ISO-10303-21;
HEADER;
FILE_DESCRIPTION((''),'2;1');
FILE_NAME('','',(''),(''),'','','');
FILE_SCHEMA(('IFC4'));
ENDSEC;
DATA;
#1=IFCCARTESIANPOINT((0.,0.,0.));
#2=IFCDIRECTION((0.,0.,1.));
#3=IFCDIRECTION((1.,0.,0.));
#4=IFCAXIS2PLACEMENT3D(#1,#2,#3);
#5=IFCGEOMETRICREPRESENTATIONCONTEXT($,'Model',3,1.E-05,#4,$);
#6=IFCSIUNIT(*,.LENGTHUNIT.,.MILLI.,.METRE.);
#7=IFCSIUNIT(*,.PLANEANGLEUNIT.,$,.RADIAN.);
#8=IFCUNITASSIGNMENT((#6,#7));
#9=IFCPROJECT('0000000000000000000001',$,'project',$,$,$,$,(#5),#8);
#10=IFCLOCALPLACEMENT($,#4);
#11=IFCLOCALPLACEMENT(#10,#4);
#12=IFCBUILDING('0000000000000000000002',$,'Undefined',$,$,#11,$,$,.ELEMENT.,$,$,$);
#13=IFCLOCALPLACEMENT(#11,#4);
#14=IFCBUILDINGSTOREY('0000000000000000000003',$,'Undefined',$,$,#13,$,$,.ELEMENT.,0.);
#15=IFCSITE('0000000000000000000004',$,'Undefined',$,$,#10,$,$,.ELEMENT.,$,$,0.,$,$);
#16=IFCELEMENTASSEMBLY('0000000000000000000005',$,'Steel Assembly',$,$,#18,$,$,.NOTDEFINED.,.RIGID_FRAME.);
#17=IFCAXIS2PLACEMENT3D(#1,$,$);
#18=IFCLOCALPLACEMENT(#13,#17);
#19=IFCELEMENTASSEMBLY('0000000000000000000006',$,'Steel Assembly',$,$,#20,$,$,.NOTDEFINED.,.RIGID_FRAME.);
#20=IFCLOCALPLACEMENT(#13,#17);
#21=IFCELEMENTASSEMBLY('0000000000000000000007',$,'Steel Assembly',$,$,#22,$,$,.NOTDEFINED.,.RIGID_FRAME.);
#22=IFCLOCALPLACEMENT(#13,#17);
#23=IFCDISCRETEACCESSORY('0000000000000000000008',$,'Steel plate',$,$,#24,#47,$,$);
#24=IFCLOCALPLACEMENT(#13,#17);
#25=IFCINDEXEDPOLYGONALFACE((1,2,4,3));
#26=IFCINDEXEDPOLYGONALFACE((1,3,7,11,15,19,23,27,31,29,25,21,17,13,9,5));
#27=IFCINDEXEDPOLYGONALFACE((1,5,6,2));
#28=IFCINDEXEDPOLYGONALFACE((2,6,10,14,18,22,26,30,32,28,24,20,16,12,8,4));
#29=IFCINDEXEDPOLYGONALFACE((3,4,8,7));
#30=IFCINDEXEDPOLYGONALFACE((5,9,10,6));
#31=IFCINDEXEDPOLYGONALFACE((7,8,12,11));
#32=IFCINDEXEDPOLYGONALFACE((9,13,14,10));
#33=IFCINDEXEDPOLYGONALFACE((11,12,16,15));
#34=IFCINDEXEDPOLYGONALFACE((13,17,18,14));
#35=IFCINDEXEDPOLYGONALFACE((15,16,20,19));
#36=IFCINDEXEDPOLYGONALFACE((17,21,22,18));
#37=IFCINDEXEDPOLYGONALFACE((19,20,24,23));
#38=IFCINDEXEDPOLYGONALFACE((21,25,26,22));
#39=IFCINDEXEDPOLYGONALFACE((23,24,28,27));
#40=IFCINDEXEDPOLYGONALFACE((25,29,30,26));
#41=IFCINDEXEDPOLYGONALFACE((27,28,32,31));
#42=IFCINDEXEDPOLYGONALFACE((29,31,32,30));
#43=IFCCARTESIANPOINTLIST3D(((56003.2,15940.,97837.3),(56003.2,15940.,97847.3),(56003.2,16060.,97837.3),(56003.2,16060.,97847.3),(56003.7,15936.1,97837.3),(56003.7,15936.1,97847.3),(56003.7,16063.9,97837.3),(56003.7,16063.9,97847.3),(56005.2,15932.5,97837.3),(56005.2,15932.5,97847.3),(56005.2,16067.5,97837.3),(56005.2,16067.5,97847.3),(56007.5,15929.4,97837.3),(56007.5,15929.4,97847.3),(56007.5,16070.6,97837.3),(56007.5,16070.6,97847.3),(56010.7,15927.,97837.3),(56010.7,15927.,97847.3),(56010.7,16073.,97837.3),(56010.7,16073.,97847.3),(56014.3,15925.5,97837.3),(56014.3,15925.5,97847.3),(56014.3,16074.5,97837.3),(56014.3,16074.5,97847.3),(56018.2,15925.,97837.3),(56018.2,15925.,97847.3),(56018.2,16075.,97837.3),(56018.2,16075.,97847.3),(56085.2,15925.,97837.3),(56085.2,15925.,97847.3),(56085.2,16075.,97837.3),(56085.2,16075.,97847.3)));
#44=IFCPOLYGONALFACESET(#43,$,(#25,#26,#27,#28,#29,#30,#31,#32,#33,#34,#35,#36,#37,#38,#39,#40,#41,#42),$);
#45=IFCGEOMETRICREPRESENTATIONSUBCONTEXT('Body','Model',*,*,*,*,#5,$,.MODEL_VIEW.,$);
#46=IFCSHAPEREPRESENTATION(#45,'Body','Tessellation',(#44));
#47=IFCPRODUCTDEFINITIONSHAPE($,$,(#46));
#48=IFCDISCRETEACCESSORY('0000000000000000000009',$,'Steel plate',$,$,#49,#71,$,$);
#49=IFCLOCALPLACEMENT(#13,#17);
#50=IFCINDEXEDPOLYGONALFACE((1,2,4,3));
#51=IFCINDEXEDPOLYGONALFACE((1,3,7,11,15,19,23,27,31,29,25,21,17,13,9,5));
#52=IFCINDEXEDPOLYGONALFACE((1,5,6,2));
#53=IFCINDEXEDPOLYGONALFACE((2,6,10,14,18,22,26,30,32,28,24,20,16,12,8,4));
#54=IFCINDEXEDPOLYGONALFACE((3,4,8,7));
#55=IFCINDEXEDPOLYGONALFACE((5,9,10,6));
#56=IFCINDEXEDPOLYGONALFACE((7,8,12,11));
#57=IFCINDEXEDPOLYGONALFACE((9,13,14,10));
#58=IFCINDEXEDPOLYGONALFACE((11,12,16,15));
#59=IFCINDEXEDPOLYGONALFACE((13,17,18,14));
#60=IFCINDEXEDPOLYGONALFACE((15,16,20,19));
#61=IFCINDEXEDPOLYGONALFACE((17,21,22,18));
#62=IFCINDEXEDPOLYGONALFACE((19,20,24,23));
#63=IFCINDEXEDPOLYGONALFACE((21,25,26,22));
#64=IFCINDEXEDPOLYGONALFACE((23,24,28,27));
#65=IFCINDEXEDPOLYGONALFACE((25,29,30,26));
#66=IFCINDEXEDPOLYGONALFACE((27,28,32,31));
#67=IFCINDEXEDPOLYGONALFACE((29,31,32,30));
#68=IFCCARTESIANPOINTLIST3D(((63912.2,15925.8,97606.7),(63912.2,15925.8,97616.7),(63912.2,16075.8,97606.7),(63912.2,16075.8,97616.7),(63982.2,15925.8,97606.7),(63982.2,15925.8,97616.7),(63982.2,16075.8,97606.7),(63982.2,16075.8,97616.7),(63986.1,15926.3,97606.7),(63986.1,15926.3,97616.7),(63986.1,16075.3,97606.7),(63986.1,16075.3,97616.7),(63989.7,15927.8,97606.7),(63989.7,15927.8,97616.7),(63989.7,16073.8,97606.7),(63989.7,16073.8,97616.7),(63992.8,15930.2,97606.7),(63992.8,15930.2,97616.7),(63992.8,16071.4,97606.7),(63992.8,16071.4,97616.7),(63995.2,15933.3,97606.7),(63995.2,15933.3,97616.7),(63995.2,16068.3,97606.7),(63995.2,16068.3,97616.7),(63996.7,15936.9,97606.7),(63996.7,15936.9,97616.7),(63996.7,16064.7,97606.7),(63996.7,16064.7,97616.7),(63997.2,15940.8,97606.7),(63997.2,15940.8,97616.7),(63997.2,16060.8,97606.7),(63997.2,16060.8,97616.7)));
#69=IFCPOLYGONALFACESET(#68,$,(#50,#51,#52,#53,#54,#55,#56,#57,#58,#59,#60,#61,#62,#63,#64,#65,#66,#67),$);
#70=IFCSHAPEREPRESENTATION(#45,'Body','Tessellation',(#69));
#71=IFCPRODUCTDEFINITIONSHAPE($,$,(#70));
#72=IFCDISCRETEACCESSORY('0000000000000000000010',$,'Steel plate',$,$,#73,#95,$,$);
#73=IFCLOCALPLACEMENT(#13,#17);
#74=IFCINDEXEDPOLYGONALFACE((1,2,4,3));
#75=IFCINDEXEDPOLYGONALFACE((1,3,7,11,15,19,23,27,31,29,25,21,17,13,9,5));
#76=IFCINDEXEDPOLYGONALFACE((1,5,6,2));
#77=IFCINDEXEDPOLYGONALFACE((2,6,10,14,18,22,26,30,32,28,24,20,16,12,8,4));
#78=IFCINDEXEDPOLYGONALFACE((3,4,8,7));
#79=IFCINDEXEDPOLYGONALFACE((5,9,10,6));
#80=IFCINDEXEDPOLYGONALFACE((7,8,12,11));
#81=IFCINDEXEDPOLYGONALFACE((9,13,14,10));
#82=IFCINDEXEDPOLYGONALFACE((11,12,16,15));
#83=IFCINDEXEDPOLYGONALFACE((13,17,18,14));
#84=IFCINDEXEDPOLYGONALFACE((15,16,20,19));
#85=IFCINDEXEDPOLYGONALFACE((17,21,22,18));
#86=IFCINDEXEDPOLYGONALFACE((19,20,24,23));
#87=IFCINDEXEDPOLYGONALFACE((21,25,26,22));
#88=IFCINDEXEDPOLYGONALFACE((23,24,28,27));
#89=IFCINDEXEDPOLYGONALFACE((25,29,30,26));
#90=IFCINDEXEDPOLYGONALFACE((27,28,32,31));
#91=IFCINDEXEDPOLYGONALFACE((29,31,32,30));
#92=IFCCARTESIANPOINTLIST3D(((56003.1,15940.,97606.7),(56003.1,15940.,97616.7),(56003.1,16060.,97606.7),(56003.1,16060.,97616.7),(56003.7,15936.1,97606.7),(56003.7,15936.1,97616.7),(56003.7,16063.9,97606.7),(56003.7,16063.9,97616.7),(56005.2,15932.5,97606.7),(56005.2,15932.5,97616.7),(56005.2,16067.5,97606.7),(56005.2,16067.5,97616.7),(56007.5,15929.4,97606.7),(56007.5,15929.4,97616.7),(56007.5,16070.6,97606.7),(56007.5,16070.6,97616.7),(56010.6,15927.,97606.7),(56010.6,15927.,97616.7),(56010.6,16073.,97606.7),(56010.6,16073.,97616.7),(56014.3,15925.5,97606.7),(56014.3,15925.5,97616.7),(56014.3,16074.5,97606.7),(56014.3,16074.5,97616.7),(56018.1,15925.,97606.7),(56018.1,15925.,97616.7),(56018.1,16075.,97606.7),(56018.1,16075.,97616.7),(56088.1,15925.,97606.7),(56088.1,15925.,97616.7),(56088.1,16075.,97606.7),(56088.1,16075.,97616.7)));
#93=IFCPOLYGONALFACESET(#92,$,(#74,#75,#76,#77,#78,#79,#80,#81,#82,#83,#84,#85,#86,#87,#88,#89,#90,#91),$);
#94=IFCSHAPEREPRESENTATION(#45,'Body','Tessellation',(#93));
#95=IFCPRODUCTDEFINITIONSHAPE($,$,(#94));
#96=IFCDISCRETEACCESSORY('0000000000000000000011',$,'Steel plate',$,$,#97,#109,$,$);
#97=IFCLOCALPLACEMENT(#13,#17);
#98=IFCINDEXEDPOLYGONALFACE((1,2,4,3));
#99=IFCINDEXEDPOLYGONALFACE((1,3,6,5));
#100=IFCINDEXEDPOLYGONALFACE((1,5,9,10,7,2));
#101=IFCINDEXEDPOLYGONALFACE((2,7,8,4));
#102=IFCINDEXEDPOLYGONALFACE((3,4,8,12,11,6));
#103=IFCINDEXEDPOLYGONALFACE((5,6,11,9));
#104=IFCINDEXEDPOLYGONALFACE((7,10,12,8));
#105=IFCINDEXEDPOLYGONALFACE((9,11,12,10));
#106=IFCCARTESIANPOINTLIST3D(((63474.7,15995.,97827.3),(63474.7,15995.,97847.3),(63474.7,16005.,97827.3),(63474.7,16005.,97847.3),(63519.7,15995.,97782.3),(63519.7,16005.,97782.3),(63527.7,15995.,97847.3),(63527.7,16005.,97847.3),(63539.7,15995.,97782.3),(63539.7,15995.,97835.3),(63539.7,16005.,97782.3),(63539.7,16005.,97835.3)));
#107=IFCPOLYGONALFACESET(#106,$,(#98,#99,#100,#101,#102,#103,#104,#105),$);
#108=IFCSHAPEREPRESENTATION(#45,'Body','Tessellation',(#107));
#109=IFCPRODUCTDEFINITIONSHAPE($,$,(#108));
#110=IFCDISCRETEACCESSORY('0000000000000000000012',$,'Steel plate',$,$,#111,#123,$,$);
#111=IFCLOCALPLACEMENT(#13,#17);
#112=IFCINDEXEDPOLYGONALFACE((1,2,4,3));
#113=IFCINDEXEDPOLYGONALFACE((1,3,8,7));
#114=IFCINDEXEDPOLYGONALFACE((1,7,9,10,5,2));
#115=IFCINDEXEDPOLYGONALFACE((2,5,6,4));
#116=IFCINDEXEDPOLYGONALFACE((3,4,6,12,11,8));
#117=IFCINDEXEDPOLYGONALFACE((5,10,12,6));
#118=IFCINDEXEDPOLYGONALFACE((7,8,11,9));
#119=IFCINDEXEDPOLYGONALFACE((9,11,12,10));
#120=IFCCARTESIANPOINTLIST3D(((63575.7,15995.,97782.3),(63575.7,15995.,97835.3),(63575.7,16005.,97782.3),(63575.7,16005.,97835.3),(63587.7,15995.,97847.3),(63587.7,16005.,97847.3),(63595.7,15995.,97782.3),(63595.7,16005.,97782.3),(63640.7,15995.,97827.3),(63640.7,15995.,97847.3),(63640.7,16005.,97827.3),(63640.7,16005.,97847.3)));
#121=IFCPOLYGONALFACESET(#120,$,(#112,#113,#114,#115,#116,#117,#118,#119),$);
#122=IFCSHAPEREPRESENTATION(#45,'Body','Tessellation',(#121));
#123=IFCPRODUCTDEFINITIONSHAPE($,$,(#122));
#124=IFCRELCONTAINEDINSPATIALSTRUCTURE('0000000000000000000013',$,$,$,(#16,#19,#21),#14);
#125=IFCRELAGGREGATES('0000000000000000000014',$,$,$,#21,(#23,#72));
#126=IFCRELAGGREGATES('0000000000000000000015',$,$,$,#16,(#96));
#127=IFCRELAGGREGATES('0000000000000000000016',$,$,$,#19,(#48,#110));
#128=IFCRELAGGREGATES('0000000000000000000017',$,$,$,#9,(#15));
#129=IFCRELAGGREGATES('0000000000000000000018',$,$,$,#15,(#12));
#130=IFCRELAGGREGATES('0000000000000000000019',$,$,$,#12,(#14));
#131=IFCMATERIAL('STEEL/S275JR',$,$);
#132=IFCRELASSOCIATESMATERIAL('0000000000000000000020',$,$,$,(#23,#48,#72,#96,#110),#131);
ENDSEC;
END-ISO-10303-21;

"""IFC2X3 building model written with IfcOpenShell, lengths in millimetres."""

from ifc_helpers import new_model, si_unit, frame, frame_2d, origin_with_axes, place, context, subcontext, project, spatial, polyline, circle_curve, parameter, trimmed, segment, composite_curve, outline, extrude, material, element, aggregate, save


model = new_model("IFC2X3")

# Units and contexts
model_context = context("Model", 3, precision=1e-05, world=origin_with_axes())
body_context = subcontext(model_context, "Body", "Model", "MODEL_VIEW")
ifc_project = project(units=[si_unit("LENGTHUNIT", "METRE", prefix="MILLI"), si_unit("PLANEANGLEUNIT", "RADIAN")], contexts=[model_context])

# Site, building, storey
site_placement = place(None, origin_with_axes())
site = spatial("IfcSite", under=ifc_project, at=site_placement, Name="Undefined", CompositionType="ELEMENT", RefElevation=0.0)
building_placement = place(site_placement, origin_with_axes())
building = spatial("IfcBuilding", under=site, at=building_placement, Name="Undefined", CompositionType="ELEMENT")
storey_placement = place(building_placement, origin_with_axes())
storey = spatial("IfcBuildingStorey", under=building, at=storey_placement, Name="Undefined", CompositionType="ELEMENT", Elevation=0.0)

# Shared definitions
ifc_material_1 = material(Name="STEEL/S275JR")

# Element assembly
assembly_1_placement = place(storey_placement, origin_with_axes())
assembly_1 = element("IfcElementAssembly", 1, at=assembly_1_placement, inside=storey, Name="Steel Assembly", AssemblyPlace="NOTDEFINED", PredefinedType="RIGID_FRAME")

# Element assembly
assembly_2_placement = place(storey_placement, origin_with_axes())
assembly_2 = element("IfcElementAssembly", 2, at=assembly_2_placement, inside=storey, Name="Steel Assembly", AssemblyPlace="NOTDEFINED", PredefinedType="RIGID_FRAME")

# Element assembly, discrete accessory
assembly_3_placement = place(storey_placement, origin_with_axes())
assembly_3 = element("IfcElementAssembly", 3, at=assembly_3_placement, inside=storey, Name="Steel Assembly", AssemblyPlace="NOTDEFINED", PredefinedType="RIGID_FRAME")
discrete_accessory_1_placement = place(assembly_3_placement, frame((56003.2, 16075.0, 97842.3), z_axis=(0.0, 0.0, -1.0), x_axis=(1.0, 0.0, 0.0)))
discrete_accessory_1 = element("IfcDiscreteAccessory", 4, at=discrete_accessory_1_placement, material=ifc_material_1, Name="Steel plate", context=body_context, shape_type="SweptSolid", body=[
    extrude(outline(composite_curve([segment(trimmed(circle_curve(frame_2d((15.0, 15.0), x_axis=(-1.0, 0.0)), 15.0), [parameter(0.0)], [parameter(1.570796)], True, "PARAMETER"), True, "CONTINUOUS"), segment(polyline([(15.0, 0.0), (82.0, 0.0), (82.0, 150.0), (15.0, 150.0)]), True, "CONTINUOUS"), segment(trimmed(circle_curve(frame_2d((15.0, 135.0), x_axis=(0.0, 1.0)), 15.0), [parameter(0.0)], [parameter(1.570796)], True, "PARAMETER"), True, "CONTINUOUS"), segment(polyline([(0.0, 135.0), (0.0, 15.0)]), True, "DISCONTINUOUS")], self_intersect=False)), frame((0.0, 0.0, -5.0), z_axis=(0.0, 0.0, 1.0), x_axis=(1.0, 0.0, 0.0)), (0.0, 0.0, 1.0), 10.0),
])

# Discrete accessories
discrete_accessory_2_placement = place(assembly_2_placement, frame((63912.2, 16075.8, 97611.7), z_axis=(0.0, -0.000204, -1.0), x_axis=(1.0, 0.000005, 0.0)))
discrete_accessory_2 = element("IfcDiscreteAccessory", 5, at=discrete_accessory_2_placement, material=ifc_material_1, Name="Steel plate", context=body_context, shape_type="SweptSolid", body=[
    extrude(outline(composite_curve([segment(polyline([(0.0, 0.0), (70.0, 0.0)]), True, "CONTINUOUS"), segment(trimmed(circle_curve(frame_2d((70.0, 15.0), x_axis=(0.0, -1.0)), 15.0), [parameter(0.0)], [parameter(1.570796)], True, "PARAMETER"), True, "CONTINUOUS"), segment(polyline([(85.0, 15.0), (85.0, 135.0)]), True, "CONTINUOUS"), segment(trimmed(circle_curve(frame_2d((70.0, 135.0), x_axis=(1.0, 0.0)), 15.0), [parameter(0.0)], [parameter(1.570796)], True, "PARAMETER"), True, "CONTINUOUS"), segment(polyline([(70.0, 150.0), (0.0, 150.0), (0.0, 0.0)]), True, "DISCONTINUOUS")], self_intersect=False)), frame((0.0, 0.0, -5.0), z_axis=(0.0, 0.0, 1.0), x_axis=(1.0, 0.0, 0.0)), (0.0, 0.0, 1.0), 10.0),
])
discrete_accessory_3_placement = place(assembly_3_placement, frame((56088.1, 16075.0, 97611.7), z_axis=(0.0, 0.0, 1.0), x_axis=(-1.0, 0.0, 0.0)))
discrete_accessory_3 = element("IfcDiscreteAccessory", 6, at=discrete_accessory_3_placement, material=ifc_material_1, Name="Steel plate", context=body_context, shape_type="SweptSolid", body=[
    extrude(outline(composite_curve([segment(polyline([(0.0, 0.0), (70.0, 0.0)]), True, "CONTINUOUS"), segment(trimmed(circle_curve(frame_2d((70.0, 15.0), x_axis=(0.0, -1.0)), 15.0), [parameter(0.0)], [parameter(1.570796)], True, "PARAMETER"), True, "CONTINUOUS"), segment(polyline([(85.0, 15.0), (85.0, 135.0)]), True, "CONTINUOUS"), segment(trimmed(circle_curve(frame_2d((70.0, 135.0), x_axis=(1.0, 0.0)), 15.0), [parameter(0.0)], [parameter(1.570796)], True, "PARAMETER"), True, "CONTINUOUS"), segment(polyline([(70.0, 150.0), (0.0, 150.0), (0.0, 0.0)]), True, "DISCONTINUOUS")], self_intersect=False)), frame((0.0, 0.0, -5.0), z_axis=(0.0, 0.0, 1.0), x_axis=(1.0, 0.0, 0.0)), (0.0, 0.0, 1.0), 10.0),
])

# Discrete accessories
discrete_accessory_4_placement = place(assembly_1_placement, frame((63474.7, 16000.0, 97847.3), z_axis=(0.0, 1.0, 0.0), x_axis=(1.0, 0.0, 0.0)))
discrete_accessory_4 = element("IfcDiscreteAccessory", 7, at=discrete_accessory_4_placement, material=ifc_material_1, Name="Steel plate", context=body_context, shape_type="SweptSolid", body=[
    extrude(outline(polyline([(0.0, 0.0), (53.0, 0.0), (65.0, 12.0), (65.0, 65.0), (45.0, 65.0), (0.0, 20.0), (0.0, 0.0)])), frame((0.0, 0.0, -5.0), z_axis=(0.0, 0.0, 1.0), x_axis=(1.0, 0.0, 0.0)), (0.0, 0.0, 1.0), 10.0),
])
discrete_accessory_5_placement = place(assembly_2_placement, frame((63640.7, 16000.0, 97847.3), z_axis=(0.0, -1.0, 0.0), x_axis=(-1.0, 0.0, 0.0)))
discrete_accessory_5 = element("IfcDiscreteAccessory", 8, at=discrete_accessory_5_placement, material=ifc_material_1, Name="Steel plate", context=body_context, shape_type="SweptSolid", body=[
    extrude(outline(polyline([(0.0, 0.0), (53.0, 0.0), (65.0, 12.0), (65.0, 65.0), (45.0, 65.0), (0.0, 20.0), (0.0, 0.0)])), frame((0.0, 0.0, -5.0), z_axis=(0.0, 0.0, 1.0), x_axis=(1.0, 0.0, 0.0)), (0.0, 0.0, 1.0), 10.0),
])

aggregate(assembly_3, [discrete_accessory_1, discrete_accessory_3])
aggregate(assembly_1, [discrete_accessory_4])
aggregate(assembly_2, [discrete_accessory_2, discrete_accessory_5])

save(model, "model.ifc")
